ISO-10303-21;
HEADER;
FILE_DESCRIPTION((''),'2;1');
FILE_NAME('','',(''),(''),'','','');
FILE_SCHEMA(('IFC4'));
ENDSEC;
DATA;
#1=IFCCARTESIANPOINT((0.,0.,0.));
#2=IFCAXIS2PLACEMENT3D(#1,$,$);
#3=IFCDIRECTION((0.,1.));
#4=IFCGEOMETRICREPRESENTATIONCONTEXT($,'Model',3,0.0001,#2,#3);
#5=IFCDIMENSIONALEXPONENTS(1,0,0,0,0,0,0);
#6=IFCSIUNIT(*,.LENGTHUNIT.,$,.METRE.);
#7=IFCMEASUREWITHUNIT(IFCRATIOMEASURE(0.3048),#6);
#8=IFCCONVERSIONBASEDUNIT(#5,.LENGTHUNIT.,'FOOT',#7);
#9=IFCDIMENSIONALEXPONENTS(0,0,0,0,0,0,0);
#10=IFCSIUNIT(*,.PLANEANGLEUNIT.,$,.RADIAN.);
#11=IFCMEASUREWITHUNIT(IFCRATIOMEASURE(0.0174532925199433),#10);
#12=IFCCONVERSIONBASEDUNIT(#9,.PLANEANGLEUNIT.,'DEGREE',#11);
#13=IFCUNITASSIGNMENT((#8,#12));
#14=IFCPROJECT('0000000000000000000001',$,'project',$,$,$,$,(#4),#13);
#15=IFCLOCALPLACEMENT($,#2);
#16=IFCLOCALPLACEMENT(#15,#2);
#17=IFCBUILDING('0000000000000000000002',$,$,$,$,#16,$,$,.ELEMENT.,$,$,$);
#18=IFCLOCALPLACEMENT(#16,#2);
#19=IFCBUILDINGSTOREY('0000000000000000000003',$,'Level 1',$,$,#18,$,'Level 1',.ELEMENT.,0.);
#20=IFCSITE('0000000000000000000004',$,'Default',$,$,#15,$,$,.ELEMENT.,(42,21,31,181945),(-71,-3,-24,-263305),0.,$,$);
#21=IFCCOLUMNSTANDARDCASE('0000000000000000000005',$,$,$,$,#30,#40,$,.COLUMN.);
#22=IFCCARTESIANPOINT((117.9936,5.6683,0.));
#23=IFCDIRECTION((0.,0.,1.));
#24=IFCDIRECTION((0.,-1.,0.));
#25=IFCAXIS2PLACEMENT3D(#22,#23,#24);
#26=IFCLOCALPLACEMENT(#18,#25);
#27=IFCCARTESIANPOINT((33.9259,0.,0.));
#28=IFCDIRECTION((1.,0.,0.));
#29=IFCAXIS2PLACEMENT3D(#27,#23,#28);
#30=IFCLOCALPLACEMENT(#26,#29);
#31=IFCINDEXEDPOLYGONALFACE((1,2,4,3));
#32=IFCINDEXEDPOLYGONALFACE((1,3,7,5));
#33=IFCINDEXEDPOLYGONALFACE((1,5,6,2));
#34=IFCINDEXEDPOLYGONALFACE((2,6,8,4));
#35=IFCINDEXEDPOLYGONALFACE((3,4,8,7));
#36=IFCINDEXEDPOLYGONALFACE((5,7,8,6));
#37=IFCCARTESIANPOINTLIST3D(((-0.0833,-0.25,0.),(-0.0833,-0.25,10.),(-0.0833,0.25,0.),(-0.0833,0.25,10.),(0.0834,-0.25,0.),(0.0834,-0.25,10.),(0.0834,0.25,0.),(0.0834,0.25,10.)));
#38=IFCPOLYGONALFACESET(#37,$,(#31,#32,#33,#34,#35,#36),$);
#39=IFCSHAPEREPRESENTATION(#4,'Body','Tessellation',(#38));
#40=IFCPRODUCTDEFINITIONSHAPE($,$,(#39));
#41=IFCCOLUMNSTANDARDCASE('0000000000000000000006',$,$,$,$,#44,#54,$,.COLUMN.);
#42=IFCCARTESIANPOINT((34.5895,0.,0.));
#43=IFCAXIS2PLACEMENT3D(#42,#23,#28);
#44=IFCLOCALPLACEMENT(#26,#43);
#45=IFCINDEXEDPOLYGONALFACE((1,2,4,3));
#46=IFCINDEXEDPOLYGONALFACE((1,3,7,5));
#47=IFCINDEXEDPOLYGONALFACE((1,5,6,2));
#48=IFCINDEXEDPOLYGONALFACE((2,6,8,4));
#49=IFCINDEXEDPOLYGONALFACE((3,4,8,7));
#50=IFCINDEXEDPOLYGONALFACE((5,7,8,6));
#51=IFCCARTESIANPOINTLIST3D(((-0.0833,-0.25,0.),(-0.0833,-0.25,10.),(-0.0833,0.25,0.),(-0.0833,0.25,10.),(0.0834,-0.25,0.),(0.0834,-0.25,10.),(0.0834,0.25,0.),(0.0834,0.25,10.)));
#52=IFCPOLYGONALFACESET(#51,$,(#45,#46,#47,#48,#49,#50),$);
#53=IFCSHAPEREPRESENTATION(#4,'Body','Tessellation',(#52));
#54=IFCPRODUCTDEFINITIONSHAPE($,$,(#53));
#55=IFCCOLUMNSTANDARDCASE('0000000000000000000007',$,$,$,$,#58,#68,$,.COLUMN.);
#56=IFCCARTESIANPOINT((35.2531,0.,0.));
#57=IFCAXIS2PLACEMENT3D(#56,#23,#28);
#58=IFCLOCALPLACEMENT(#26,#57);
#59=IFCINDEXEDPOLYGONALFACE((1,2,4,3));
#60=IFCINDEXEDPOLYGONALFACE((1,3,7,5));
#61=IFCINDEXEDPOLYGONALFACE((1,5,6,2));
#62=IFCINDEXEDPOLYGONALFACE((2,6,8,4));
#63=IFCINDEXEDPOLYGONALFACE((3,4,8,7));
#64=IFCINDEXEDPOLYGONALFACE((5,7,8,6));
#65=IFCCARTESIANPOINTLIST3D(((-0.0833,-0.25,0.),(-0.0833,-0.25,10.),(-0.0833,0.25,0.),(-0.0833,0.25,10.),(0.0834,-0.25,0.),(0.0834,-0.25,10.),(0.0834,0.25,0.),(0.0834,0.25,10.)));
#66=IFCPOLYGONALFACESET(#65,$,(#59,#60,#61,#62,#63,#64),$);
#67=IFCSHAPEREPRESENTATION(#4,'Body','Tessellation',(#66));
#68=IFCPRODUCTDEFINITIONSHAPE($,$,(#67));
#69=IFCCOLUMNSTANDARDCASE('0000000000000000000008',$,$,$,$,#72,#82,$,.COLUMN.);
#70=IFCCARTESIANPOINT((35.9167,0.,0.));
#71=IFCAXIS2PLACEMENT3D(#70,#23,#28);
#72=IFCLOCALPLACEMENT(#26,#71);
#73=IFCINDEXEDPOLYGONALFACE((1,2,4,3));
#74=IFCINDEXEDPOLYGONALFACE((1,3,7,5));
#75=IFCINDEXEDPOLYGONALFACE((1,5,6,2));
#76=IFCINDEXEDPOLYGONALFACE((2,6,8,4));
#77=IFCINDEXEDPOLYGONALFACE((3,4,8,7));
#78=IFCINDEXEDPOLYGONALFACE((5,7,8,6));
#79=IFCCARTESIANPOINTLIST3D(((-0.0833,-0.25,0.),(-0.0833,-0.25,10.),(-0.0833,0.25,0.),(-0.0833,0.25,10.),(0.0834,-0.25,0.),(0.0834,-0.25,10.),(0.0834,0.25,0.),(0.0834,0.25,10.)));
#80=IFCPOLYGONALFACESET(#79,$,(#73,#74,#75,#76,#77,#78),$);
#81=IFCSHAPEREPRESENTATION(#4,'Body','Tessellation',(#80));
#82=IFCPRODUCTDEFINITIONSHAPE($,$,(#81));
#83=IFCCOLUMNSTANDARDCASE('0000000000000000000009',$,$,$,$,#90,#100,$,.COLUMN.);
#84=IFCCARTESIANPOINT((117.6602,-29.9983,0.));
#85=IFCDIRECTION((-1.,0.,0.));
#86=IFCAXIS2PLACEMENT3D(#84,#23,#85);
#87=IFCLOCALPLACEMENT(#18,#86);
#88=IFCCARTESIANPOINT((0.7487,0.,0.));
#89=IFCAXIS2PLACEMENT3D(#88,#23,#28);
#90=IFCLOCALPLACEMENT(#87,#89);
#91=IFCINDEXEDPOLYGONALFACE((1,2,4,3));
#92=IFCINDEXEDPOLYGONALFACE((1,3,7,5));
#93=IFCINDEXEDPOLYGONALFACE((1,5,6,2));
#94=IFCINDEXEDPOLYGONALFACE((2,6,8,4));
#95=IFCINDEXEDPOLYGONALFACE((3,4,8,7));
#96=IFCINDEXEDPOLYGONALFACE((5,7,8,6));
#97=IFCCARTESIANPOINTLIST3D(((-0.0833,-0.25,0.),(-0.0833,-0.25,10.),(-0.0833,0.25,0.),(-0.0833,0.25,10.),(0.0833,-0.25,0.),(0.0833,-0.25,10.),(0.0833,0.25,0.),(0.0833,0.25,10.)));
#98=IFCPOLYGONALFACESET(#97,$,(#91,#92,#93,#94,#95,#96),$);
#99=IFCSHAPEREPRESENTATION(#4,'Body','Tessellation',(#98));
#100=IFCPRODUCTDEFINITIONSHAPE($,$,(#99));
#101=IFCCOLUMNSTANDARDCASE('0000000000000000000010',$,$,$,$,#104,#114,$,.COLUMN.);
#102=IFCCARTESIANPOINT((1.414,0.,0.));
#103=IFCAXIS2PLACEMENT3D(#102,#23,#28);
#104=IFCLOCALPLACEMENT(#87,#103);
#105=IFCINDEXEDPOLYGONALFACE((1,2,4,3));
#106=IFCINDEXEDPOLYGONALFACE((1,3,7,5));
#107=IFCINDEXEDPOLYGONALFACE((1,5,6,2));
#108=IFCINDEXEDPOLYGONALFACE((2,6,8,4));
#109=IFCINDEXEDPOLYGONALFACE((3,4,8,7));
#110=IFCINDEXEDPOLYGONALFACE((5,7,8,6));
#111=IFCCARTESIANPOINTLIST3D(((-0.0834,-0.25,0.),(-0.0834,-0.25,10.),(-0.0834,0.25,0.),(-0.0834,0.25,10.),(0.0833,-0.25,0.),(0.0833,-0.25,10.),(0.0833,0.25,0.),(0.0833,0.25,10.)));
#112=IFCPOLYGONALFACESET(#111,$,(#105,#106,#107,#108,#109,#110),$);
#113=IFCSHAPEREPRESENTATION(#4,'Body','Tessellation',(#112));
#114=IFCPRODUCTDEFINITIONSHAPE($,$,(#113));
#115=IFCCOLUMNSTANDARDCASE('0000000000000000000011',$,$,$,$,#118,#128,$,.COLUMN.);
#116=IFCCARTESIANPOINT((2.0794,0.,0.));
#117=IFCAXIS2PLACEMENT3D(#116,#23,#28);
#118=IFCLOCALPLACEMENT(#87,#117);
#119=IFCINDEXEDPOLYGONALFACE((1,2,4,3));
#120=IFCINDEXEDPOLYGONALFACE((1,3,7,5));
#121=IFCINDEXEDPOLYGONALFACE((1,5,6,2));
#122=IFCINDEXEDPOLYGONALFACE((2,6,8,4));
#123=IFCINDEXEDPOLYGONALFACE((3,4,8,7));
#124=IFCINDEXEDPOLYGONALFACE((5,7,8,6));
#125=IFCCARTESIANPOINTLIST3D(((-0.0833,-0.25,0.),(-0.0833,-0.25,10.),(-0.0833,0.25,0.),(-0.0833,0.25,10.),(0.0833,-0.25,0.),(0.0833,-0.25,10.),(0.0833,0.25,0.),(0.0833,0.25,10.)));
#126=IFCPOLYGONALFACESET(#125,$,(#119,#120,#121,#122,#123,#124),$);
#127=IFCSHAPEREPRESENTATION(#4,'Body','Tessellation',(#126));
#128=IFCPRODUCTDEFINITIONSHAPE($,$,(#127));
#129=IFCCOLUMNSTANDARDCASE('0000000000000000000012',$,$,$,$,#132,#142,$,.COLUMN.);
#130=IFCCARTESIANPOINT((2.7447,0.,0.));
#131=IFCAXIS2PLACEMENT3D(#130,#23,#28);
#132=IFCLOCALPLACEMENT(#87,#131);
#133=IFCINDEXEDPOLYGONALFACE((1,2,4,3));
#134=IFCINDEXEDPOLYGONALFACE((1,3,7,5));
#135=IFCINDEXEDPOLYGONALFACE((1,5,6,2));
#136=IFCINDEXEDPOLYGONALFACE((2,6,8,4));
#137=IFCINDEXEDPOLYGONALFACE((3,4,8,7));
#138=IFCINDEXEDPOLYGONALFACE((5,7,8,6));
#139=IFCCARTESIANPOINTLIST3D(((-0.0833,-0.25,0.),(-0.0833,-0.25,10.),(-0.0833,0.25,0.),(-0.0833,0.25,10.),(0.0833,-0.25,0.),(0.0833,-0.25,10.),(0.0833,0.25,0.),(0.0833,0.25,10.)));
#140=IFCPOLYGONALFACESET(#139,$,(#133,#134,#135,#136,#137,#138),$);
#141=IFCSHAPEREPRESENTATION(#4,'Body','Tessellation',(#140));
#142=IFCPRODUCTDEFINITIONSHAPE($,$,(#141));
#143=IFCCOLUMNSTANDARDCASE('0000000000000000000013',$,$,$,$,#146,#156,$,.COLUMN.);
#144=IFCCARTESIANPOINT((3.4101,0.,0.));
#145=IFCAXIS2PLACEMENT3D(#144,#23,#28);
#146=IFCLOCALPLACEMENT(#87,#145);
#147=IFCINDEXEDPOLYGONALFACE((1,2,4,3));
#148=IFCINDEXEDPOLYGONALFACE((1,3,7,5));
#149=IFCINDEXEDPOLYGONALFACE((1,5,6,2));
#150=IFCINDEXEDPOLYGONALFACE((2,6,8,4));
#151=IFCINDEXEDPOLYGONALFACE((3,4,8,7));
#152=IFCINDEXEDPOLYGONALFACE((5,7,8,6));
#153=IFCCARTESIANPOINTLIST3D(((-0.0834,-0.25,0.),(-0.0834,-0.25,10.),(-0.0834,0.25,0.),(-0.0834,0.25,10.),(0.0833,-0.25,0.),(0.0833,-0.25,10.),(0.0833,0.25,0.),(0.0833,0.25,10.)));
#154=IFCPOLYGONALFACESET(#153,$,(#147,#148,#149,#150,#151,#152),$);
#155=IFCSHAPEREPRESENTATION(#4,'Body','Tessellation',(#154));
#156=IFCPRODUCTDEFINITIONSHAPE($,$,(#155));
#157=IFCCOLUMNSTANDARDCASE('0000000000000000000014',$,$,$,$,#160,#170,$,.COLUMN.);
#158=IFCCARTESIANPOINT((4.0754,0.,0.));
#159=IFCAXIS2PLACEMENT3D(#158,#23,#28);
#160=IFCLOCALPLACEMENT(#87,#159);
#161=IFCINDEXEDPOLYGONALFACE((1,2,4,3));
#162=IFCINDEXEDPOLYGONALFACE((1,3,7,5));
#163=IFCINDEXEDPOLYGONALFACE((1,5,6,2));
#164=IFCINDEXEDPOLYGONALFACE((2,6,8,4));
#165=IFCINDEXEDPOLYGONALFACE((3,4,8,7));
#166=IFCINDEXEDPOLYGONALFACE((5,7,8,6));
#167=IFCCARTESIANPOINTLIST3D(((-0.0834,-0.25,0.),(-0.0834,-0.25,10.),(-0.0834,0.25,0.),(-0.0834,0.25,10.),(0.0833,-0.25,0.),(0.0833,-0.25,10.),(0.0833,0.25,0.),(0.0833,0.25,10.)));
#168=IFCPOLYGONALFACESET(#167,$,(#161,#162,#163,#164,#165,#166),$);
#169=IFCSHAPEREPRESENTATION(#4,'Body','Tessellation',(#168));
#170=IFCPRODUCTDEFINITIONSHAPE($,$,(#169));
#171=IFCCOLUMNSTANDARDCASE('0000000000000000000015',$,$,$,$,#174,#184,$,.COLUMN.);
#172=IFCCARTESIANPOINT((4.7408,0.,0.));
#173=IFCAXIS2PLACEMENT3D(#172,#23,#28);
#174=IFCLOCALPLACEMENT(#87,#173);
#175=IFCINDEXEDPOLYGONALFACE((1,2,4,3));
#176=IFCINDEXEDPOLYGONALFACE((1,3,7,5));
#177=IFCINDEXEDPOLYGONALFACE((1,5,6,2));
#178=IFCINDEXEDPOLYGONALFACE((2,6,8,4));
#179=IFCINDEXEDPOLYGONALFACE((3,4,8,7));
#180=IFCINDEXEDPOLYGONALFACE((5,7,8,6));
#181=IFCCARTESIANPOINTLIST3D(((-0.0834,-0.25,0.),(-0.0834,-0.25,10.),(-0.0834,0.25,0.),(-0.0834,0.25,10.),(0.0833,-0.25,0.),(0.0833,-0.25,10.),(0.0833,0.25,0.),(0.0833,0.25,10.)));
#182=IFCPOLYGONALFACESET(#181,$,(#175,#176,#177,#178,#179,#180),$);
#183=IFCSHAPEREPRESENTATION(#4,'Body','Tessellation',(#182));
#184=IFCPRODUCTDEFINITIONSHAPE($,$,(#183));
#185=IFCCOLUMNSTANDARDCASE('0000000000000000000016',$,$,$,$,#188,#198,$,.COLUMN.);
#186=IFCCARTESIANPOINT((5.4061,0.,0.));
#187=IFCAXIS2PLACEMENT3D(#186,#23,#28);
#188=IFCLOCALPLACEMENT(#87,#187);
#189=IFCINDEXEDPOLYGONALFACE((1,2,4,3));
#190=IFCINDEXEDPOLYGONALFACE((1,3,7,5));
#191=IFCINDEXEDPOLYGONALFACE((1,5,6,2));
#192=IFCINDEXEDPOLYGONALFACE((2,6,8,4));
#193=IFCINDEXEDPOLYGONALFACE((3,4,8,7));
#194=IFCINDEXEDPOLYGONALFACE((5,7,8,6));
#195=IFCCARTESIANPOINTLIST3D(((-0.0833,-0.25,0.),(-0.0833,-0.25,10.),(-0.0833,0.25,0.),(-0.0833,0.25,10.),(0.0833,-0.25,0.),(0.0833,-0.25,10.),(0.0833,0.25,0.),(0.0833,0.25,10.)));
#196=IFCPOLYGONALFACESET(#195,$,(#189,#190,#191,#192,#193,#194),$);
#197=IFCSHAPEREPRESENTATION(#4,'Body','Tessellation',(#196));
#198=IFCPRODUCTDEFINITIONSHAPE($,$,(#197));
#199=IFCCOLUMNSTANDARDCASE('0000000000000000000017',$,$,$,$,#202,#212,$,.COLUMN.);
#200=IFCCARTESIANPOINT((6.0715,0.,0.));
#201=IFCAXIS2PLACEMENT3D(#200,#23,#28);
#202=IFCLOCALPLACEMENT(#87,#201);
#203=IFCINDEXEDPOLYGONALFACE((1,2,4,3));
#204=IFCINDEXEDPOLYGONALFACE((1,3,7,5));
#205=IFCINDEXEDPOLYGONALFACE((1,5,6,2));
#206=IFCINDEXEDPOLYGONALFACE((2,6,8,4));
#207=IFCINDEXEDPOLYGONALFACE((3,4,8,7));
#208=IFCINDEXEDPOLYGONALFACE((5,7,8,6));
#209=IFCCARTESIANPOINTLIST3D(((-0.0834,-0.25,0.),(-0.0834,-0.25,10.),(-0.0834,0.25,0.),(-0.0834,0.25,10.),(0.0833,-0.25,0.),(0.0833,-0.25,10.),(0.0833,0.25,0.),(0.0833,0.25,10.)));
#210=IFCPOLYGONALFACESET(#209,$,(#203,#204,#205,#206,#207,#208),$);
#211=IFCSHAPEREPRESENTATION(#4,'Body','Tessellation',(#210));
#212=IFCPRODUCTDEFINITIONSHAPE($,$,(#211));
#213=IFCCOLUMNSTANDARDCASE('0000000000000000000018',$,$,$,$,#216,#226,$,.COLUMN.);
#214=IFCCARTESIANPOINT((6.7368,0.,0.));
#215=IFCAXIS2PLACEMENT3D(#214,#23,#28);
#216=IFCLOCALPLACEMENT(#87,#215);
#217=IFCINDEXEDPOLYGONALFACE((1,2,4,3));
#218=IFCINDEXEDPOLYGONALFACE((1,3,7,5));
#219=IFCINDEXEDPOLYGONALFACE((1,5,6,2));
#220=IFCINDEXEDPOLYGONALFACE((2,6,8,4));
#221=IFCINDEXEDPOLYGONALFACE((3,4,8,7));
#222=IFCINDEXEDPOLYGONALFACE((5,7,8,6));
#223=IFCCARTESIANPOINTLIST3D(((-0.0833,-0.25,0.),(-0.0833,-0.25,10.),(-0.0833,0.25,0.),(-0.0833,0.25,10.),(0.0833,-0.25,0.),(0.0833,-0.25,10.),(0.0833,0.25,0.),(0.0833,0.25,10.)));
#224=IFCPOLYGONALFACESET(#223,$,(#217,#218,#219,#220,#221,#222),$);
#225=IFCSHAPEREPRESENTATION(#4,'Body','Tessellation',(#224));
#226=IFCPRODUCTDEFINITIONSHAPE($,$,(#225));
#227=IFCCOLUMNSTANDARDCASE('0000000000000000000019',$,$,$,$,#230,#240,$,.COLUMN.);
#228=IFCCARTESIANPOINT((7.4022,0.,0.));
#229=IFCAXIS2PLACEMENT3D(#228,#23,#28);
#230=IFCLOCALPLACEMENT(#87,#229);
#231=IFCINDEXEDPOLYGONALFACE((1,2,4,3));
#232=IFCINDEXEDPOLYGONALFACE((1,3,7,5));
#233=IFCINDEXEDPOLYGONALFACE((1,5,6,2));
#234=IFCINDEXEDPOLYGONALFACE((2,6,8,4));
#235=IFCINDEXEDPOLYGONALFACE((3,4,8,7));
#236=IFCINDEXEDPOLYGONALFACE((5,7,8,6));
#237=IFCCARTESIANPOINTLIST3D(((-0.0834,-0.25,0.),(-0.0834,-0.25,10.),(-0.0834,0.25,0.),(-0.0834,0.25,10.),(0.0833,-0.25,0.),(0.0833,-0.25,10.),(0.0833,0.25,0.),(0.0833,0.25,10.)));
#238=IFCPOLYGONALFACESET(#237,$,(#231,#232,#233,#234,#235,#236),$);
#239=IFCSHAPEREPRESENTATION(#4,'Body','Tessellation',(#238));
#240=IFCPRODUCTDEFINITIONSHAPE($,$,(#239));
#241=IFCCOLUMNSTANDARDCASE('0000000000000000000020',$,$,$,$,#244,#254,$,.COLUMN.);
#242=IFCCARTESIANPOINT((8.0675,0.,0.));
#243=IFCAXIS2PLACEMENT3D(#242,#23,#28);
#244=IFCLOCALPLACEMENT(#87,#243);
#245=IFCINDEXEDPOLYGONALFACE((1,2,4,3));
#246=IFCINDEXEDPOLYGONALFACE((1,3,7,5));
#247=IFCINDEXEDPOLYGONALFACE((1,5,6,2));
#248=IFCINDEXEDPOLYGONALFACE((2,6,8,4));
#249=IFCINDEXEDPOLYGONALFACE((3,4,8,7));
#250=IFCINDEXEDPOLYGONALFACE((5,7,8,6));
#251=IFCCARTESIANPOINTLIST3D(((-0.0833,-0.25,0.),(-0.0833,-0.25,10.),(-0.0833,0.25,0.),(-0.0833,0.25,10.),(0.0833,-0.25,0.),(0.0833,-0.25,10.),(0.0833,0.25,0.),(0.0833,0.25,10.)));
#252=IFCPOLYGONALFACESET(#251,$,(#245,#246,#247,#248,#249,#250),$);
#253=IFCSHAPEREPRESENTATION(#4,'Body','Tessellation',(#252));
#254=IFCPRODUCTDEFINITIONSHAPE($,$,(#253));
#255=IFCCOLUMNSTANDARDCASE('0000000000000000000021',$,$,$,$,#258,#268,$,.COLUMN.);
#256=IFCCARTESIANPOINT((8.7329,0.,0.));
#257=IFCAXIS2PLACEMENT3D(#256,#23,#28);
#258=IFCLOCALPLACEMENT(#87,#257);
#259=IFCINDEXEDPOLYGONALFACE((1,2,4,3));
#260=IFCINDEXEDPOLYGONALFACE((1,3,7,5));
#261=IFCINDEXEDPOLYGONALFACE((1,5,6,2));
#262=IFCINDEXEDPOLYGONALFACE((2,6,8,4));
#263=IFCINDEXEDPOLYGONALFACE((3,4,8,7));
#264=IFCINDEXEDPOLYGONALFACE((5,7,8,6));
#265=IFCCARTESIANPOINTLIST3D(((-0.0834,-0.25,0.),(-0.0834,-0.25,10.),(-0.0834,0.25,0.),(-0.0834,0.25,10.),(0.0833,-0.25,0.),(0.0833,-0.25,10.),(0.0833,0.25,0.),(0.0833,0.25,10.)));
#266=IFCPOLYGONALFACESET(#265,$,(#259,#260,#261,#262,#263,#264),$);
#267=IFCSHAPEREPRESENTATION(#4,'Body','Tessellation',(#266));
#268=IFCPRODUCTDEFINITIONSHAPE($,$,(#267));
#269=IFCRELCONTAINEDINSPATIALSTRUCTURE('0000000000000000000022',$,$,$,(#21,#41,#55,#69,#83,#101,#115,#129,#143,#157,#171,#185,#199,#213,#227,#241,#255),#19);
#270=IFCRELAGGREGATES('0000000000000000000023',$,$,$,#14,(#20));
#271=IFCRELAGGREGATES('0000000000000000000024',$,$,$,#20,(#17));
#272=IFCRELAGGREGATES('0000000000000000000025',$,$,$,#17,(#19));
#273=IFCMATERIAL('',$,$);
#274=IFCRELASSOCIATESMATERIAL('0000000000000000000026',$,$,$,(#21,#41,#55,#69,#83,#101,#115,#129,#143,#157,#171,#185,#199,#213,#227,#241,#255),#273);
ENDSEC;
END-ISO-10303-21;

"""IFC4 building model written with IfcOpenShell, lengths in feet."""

from ifc_helpers import new_model, entity, si_unit, converted_unit, direction, frame, origin, place, context, project, spatial, rectangle, extrude, material, element, save


model = new_model("IFC4")

# Units and contexts
model_context = context("Model", 3, precision=0.0001, world=origin(), true_north=direction((0.0, 1.0)))
ifc_project = project(units=[converted_unit("LENGTHUNIT", "FOOT", entity("IfcRatioMeasure", 0.3048), si_unit("LENGTHUNIT", "METRE"), dimensions=[1, 0, 0, 0, 0, 0, 0]), converted_unit("PLANEANGLEUNIT", "DEGREE", entity("IfcRatioMeasure", 0.0174532925199433), si_unit("PLANEANGLEUNIT", "RADIAN"), dimensions=[0, 0, 0, 0, 0, 0, 0])], contexts=[model_context])

# Site, building, storey
site_placement = place(None, origin())
site = spatial("IfcSite", under=ifc_project, at=site_placement, Name="Default", CompositionType="ELEMENT", RefLatitude=(42, 21, 31, 181945), RefLongitude=(-71, -3, -24, -263305), RefElevation=0.0)
building_placement = place(site_placement, origin())
building = spatial("IfcBuilding", under=site, at=building_placement, CompositionType="ELEMENT")
storey_placement = place(building_placement, origin())
storey = spatial("IfcBuildingStorey", under=building, at=storey_placement, Name="Level 1", LongName="Level 1", CompositionType="ELEMENT", Elevation=0.0)

# Columns
ifc_material_1 = material(Name="")
placement = place(storey_placement, frame((117.9936, 5.6683, 0.0), z_axis=(0.0, 0.0, 1.0), x_axis=(0.0, -1.0, 0.0)))
for number, where, z_axis, x_axis in (
    (1, (33.9259, 0.0, 0.0), (0.0, 0.0, 1.0), (1.0, 0.0, 0.0)),
    (2, (34.5895, 0.0, 0.0), (0.0, 0.0, 1.0), (1.0, 0.0, 0.0)),
    (3, (35.2531, 0.0, 0.0), (0.0, 0.0, 1.0), (1.0, 0.0, 0.0)),
    (4, (35.9167, 0.0, 0.0), (0.0, 0.0, 1.0), (1.0, 0.0, 0.0)),
):
    element("IfcColumnStandardCase", number, at=place(placement, frame(where, z_axis=z_axis, x_axis=x_axis)), inside=storey, material=ifc_material_1, PredefinedType="COLUMN", context=model_context, shape_type="SweptSolid", body=[
        extrude(rectangle(XDim=0.1667, YDim=0.5), origin(), (0.0, 0.0, 1.0), 10.0),
    ])
wall_placement = place(storey_placement, frame((117.6602, -29.9983, 0.0), z_axis=(0.0, 0.0, 1.0), x_axis=(-1.0, 0.0, 0.0)))
for number, where, z_axis, x_axis in (
    (5, (0.7487, 0.0, 0.0), (0.0, 0.0, 1.0), (1.0, 0.0, 0.0)),
    (6, (1.414, 0.0, 0.0), (0.0, 0.0, 1.0), (1.0, 0.0, 0.0)),
    (7, (2.0794, 0.0, 0.0), (0.0, 0.0, 1.0), (1.0, 0.0, 0.0)),
    (8, (2.7447, 0.0, 0.0), (0.0, 0.0, 1.0), (1.0, 0.0, 0.0)),
    (9, (3.4101, 0.0, 0.0), (0.0, 0.0, 1.0), (1.0, 0.0, 0.0)),
    (10, (4.0754, 0.0, 0.0), (0.0, 0.0, 1.0), (1.0, 0.0, 0.0)),
    (11, (4.7408, 0.0, 0.0), (0.0, 0.0, 1.0), (1.0, 0.0, 0.0)),
    (12, (5.4061, 0.0, 0.0), (0.0, 0.0, 1.0), (1.0, 0.0, 0.0)),
    (13, (6.0715, 0.0, 0.0), (0.0, 0.0, 1.0), (1.0, 0.0, 0.0)),
    (14, (6.7368, 0.0, 0.0), (0.0, 0.0, 1.0), (1.0, 0.0, 0.0)),
    (15, (7.4022, 0.0, 0.0), (0.0, 0.0, 1.0), (1.0, 0.0, 0.0)),
    (16, (8.0675, 0.0, 0.0), (0.0, 0.0, 1.0), (1.0, 0.0, 0.0)),
    (17, (8.7329, 0.0, 0.0), (0.0, 0.0, 1.0), (1.0, 0.0, 0.0)),
):
    element("IfcColumnStandardCase", number, at=place(wall_placement, frame(where, z_axis=z_axis, x_axis=x_axis)), inside=storey, material=ifc_material_1, PredefinedType="COLUMN", context=model_context, shape_type="SweptSolid", body=[
        extrude(rectangle(XDim=0.1667, YDim=0.5), origin(), (0.0, 0.0, 1.0), 10.0),
    ])

save(model, "model.ifc")
